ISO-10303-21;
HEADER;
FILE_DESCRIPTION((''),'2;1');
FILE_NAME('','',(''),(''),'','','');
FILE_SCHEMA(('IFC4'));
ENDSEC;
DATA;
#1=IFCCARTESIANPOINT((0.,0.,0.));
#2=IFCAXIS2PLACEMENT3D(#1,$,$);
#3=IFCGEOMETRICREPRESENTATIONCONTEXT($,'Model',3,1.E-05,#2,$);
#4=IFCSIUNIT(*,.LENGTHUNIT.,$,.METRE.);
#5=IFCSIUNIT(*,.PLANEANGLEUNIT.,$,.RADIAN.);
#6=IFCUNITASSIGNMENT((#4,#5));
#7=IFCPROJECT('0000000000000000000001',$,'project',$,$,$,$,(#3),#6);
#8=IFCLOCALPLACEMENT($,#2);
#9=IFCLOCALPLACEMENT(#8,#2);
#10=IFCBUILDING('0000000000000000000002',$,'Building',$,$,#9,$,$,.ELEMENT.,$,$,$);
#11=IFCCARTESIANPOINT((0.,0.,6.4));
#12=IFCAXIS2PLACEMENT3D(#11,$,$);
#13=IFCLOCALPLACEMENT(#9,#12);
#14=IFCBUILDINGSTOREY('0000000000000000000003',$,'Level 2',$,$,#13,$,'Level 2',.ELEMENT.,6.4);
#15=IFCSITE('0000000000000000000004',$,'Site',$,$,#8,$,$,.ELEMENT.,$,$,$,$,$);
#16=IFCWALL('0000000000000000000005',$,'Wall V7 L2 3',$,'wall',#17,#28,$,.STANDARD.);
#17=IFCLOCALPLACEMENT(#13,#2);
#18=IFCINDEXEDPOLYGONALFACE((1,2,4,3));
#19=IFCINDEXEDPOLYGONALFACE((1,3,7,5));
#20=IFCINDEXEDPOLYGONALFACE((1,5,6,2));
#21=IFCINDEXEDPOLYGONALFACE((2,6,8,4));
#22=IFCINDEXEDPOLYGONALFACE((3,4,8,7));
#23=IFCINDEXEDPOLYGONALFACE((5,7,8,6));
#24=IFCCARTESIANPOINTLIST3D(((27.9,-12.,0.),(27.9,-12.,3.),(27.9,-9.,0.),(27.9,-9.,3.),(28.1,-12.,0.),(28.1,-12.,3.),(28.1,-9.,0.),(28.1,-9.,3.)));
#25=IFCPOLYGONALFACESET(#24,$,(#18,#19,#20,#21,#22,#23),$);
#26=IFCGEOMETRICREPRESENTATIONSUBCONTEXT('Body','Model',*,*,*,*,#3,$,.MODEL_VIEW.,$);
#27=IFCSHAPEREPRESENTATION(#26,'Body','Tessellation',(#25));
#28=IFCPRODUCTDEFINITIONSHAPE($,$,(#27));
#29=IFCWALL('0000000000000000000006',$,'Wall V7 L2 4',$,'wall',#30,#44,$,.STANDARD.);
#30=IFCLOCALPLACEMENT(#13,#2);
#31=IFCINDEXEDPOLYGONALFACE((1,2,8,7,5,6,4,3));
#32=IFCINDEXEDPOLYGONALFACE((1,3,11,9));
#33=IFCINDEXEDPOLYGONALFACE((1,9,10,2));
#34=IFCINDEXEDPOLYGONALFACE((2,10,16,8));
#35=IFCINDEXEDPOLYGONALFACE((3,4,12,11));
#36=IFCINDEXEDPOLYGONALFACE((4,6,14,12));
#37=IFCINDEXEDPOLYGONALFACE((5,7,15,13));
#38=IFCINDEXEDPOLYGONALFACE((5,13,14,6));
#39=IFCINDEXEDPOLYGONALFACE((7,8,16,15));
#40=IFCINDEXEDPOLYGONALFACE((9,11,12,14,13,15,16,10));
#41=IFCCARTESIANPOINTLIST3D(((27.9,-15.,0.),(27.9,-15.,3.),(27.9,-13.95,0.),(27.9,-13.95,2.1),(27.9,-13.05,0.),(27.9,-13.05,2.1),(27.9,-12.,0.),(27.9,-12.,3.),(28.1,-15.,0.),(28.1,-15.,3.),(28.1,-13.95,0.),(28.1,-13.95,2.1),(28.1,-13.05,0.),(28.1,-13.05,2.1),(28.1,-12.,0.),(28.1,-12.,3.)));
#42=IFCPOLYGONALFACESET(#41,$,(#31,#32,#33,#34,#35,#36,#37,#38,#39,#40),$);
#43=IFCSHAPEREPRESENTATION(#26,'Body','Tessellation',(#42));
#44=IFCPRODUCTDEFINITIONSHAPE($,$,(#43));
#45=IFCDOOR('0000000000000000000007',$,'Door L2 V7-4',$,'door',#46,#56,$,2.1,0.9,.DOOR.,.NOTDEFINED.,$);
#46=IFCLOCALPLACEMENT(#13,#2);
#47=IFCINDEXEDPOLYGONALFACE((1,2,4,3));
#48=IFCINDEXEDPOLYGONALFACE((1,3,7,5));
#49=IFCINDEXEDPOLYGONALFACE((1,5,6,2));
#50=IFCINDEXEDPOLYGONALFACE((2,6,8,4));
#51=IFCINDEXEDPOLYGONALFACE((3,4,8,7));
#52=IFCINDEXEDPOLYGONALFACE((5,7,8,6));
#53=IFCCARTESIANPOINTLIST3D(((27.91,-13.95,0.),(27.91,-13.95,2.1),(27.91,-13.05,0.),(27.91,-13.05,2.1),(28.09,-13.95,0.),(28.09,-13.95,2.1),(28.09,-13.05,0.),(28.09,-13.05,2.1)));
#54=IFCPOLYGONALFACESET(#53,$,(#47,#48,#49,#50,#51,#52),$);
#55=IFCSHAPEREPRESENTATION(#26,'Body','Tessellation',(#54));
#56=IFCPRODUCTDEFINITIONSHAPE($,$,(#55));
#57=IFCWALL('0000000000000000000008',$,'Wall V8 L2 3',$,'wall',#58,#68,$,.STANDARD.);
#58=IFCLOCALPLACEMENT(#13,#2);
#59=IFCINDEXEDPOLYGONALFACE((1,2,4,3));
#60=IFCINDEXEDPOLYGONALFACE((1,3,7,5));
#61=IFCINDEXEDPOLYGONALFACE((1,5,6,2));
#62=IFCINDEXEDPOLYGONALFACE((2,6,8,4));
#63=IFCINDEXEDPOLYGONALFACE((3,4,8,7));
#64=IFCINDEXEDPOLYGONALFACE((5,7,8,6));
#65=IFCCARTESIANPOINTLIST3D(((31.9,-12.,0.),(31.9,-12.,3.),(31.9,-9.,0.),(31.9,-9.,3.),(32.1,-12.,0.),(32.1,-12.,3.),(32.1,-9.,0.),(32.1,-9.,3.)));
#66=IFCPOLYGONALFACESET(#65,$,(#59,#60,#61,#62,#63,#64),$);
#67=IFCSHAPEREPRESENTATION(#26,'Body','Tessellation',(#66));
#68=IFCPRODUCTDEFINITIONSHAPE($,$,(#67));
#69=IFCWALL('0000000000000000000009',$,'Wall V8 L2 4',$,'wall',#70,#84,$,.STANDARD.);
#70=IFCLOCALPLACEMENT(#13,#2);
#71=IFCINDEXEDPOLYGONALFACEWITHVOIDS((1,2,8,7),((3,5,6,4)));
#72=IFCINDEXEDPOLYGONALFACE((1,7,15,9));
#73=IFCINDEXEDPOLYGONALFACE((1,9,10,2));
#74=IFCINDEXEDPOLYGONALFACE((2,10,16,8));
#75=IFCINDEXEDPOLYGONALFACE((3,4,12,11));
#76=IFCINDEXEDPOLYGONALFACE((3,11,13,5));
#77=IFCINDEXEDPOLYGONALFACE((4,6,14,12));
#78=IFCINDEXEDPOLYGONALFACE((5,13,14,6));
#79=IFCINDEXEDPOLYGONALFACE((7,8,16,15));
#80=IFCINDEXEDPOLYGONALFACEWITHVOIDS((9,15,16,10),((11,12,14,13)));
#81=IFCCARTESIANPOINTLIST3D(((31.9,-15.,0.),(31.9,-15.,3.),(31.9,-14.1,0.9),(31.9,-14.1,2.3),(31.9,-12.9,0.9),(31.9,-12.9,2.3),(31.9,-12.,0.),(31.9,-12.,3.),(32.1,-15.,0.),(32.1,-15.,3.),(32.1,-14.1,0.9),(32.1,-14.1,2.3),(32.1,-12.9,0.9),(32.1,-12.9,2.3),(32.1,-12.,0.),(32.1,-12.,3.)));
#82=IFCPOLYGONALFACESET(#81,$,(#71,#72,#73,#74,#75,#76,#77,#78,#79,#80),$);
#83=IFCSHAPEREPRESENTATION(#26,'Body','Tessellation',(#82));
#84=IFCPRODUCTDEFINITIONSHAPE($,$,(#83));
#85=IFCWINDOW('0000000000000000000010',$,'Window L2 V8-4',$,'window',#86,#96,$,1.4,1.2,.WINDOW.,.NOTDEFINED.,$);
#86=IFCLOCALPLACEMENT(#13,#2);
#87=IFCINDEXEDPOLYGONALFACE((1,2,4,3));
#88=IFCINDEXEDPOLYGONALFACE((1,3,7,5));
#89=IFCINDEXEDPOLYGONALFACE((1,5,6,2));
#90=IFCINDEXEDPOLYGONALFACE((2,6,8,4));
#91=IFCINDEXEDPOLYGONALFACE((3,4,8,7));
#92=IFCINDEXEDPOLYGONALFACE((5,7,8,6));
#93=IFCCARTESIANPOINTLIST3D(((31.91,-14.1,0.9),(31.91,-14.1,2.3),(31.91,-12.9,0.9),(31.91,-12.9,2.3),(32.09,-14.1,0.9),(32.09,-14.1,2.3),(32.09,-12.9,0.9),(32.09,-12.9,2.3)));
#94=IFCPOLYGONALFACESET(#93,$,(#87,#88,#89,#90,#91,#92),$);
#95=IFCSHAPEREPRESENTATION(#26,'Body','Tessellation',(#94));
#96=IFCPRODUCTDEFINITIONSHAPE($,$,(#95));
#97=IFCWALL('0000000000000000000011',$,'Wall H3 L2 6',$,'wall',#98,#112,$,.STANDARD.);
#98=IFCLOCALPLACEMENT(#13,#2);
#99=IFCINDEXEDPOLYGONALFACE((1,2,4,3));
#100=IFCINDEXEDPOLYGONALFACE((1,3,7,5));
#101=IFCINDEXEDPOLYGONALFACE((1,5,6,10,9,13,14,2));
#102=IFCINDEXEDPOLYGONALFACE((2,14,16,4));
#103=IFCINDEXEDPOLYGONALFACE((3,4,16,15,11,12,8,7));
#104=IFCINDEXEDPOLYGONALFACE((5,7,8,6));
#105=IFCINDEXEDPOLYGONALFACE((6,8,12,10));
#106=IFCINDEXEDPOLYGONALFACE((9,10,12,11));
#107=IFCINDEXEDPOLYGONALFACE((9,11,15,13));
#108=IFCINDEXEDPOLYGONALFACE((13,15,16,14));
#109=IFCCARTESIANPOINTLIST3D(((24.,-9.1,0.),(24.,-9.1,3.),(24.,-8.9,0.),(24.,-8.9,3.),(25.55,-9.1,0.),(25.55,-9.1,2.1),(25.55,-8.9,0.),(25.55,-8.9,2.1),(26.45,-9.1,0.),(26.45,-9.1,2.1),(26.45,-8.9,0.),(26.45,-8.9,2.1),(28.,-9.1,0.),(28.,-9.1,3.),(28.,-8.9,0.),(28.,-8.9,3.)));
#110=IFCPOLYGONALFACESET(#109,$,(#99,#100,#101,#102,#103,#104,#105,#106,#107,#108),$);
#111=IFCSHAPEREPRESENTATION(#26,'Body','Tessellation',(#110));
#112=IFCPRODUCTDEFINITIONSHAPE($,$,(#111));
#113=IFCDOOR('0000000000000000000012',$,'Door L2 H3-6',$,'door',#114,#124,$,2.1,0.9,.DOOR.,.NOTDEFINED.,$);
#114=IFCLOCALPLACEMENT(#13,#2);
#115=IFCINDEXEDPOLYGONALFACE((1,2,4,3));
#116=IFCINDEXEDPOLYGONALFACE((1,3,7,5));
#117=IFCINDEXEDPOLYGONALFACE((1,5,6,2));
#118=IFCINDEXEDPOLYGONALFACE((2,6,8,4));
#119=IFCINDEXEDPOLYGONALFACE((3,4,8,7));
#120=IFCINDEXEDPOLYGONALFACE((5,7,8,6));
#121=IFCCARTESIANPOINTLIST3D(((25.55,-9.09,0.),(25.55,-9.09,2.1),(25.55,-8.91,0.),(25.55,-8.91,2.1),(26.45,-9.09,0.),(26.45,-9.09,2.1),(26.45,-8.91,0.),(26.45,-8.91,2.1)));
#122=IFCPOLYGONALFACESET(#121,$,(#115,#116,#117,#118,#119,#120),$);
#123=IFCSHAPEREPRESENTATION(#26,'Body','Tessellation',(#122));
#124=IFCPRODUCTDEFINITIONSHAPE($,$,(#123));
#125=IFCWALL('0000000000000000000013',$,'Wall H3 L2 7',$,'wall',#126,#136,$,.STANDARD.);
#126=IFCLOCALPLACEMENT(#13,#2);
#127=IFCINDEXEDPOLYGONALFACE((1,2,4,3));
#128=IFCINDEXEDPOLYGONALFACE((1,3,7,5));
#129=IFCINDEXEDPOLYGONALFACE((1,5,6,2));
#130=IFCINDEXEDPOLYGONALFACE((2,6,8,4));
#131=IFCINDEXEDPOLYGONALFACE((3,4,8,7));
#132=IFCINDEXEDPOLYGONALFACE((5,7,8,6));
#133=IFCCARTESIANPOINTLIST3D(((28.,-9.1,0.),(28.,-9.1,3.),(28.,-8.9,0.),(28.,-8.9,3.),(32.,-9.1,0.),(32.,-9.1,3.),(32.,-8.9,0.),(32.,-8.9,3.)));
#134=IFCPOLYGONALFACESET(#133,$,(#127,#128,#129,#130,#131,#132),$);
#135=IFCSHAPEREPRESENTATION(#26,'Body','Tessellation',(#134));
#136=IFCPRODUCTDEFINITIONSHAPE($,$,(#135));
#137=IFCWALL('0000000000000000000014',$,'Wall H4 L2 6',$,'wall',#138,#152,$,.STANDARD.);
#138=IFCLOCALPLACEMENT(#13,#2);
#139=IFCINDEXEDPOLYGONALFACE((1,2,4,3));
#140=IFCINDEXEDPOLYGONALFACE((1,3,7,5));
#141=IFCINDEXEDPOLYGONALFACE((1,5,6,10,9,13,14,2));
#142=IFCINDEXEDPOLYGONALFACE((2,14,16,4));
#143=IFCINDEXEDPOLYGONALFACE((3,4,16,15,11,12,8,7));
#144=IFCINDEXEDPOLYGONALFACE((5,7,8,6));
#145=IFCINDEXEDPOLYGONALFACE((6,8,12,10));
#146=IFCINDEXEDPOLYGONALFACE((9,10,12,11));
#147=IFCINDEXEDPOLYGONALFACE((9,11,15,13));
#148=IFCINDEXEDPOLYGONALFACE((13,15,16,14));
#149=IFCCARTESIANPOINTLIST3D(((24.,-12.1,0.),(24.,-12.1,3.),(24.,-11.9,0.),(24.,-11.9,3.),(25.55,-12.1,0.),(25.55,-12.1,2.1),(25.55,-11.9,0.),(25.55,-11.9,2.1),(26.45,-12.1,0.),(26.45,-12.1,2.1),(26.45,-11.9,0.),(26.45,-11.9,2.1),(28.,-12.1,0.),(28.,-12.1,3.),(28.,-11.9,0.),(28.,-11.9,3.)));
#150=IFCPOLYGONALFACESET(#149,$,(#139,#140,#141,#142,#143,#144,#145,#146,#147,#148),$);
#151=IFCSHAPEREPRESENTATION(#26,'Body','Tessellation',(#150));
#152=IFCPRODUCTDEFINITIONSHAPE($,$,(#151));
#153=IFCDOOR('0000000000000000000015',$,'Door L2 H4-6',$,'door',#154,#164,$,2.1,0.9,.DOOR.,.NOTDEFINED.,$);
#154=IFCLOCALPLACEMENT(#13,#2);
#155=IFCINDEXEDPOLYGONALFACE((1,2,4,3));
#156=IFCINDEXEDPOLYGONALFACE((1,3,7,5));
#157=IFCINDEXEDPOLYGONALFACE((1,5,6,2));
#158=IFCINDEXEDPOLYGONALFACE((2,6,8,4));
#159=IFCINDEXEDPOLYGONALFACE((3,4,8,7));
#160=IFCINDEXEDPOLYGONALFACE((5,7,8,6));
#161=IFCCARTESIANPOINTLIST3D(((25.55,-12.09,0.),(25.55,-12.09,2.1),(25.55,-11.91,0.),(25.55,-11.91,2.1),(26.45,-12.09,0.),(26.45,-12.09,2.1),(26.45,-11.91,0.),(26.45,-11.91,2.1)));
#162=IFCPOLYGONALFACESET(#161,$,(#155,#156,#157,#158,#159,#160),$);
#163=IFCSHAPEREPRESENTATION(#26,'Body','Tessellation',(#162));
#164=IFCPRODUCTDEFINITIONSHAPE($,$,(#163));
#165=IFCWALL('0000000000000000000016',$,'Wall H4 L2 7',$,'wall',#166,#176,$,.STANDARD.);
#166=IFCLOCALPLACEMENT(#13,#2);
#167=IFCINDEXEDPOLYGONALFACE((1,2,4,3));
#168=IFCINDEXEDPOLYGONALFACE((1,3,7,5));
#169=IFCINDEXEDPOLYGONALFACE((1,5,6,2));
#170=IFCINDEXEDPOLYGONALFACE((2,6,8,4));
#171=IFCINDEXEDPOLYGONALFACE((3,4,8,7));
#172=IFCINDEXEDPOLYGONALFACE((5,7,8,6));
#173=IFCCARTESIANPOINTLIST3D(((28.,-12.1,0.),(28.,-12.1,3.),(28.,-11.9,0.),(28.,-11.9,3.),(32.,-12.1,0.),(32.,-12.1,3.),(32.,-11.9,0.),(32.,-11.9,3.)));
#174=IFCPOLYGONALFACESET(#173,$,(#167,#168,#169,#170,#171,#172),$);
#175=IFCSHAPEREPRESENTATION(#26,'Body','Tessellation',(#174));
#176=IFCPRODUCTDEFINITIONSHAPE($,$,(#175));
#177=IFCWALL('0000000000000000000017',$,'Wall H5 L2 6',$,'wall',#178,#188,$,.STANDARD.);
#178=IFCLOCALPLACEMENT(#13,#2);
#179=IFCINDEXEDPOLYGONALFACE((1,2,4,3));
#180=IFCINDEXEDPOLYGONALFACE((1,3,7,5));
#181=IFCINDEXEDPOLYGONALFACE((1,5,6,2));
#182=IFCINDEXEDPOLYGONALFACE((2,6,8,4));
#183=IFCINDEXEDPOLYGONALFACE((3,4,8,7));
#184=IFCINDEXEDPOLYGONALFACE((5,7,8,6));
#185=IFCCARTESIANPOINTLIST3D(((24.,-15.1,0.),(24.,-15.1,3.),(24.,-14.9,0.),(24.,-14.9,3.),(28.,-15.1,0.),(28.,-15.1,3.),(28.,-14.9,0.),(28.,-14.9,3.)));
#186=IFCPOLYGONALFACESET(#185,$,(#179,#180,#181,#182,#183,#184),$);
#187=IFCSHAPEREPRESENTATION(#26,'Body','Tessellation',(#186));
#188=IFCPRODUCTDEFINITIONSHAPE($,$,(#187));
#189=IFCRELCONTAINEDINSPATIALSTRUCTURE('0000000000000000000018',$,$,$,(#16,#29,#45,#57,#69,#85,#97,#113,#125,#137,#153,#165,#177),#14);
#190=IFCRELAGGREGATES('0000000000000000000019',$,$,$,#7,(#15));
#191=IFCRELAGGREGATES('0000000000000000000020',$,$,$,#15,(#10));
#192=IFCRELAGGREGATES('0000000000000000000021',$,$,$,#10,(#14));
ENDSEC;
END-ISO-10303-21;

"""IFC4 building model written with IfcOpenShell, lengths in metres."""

from ifc_helpers import new_model, si_unit, frame, frame_2d, origin, origin_2d, place, context, subcontext, project, spatial, rectangle, extrude, element, fill, save


model = new_model("IFC4")

# Units and contexts
model_context = context("Model", 3, precision=1e-05, world=origin())
body_context = subcontext(model_context, "Body", "Model", "MODEL_VIEW")
ifc_project = project(units=[si_unit("LENGTHUNIT", "METRE"), si_unit("PLANEANGLEUNIT", "RADIAN")], contexts=[model_context])

# Site, building, storey
site_placement = place(None, origin())
site = spatial("IfcSite", under=ifc_project, at=site_placement, Name="Site", CompositionType="ELEMENT")
building_placement = place(site_placement, origin())
building = spatial("IfcBuilding", under=site, at=building_placement, Name="Building", CompositionType="ELEMENT")
storey_placement = place(building_placement, frame((0.0, 0.0, 6.4)))
storey = spatial("IfcBuildingStorey", under=building, at=storey_placement, Name="Level 2", LongName="Level 2", CompositionType="ELEMENT", Elevation=6.4)

# Wall
wall_1_placement = place(storey_placement, frame((28.0, -9.0, 0.0), z_axis=(0.0, 0.0, 1.0), x_axis=(0.0, -1.0, 0.0)))
element("IfcWall", 1, at=wall_1_placement, inside=storey, Name="Wall V7 L2 3", ObjectType="wall", PredefinedType="STANDARD", context=body_context, shape_type="SweptSolid", body=[
    extrude(rectangle(XDim=3.0, YDim=0.2, at=frame_2d((1.5, 0.0))), origin(), (0.0, 0.0, 1.0), 3.0),
])

# Wall, opening, door
wall_2_placement = place(storey_placement, frame((28.0, -12.0, 0.0), z_axis=(0.0, 0.0, 1.0), x_axis=(0.0, -1.0, 0.0)))
wall_2 = element("IfcWall", 2, at=wall_2_placement, inside=storey, Name="Wall V7 L2 4", ObjectType="wall", PredefinedType="STANDARD", context=body_context, shape_type="SweptSolid", body=[
    extrude(rectangle(XDim=3.0, YDim=0.2, at=frame_2d((1.5, 0.0))), origin(), (0.0, 0.0, 1.0), 3.0),
])
opening_1_placement = place(storey_placement, frame((28.0, -13.5, 0.0), z_axis=(0.0, 0.0, 1.0), x_axis=(0.0, -1.0, 0.0)))
opening_1 = element("IfcOpeningElement", 3, at=opening_1_placement, cuts=wall_2, ObjectType="Opening", PredefinedType="OPENING", context=body_context, shape_type="SweptSolid", body=[
    extrude(rectangle(XDim=0.9, YDim=0.22, at=origin_2d()), origin(), (0.0, 0.0, 1.0), 2.1),
])
door_1_placement = place(storey_placement, frame((28.0, -13.5, 0.0), z_axis=(0.0, 0.0, 1.0), x_axis=(0.0, -1.0, 0.0)))
door_1 = element("IfcDoor", 4, at=door_1_placement, inside=storey, Name="Door L2 V7-4", ObjectType="door", OperationType="NOTDEFINED", OverallHeight=2.1, OverallWidth=0.9, PredefinedType="DOOR", context=body_context, shape_type="SweptSolid", body=[
    extrude(rectangle(XDim=0.9, YDim=0.18, at=origin_2d()), origin(), (0.0, 0.0, 1.0), 2.1),
])
fill(opening_1, door_1)

# Wall
wall_3_placement = place(storey_placement, frame((32.0, -9.0, 0.0), z_axis=(0.0, 0.0, 1.0), x_axis=(0.0, -1.0, 0.0)))
element("IfcWall", 5, at=wall_3_placement, inside=storey, Name="Wall V8 L2 3", ObjectType="wall", PredefinedType="STANDARD", context=body_context, shape_type="SweptSolid", body=[
    extrude(rectangle(XDim=3.0, YDim=0.2, at=frame_2d((1.5, 0.0))), origin(), (0.0, 0.0, 1.0), 3.0),
])

# Wall, opening, window
wall_4_placement = place(storey_placement, frame((32.0, -12.0, 0.0), z_axis=(0.0, 0.0, 1.0), x_axis=(0.0, -1.0, 0.0)))
wall_4 = element("IfcWall", 6, at=wall_4_placement, inside=storey, Name="Wall V8 L2 4", ObjectType="wall", PredefinedType="STANDARD", context=body_context, shape_type="SweptSolid", body=[
    extrude(rectangle(XDim=3.0, YDim=0.2, at=frame_2d((1.5, 0.0))), origin(), (0.0, 0.0, 1.0), 3.0),
])
opening_2_placement = place(storey_placement, frame((32.0, -13.5, 0.9), z_axis=(0.0, 0.0, 1.0), x_axis=(0.0, -1.0, 0.0)))
opening_2 = element("IfcOpeningElement", 7, at=opening_2_placement, cuts=wall_4, ObjectType="Opening", PredefinedType="OPENING", context=body_context, shape_type="SweptSolid", body=[
    extrude(rectangle(XDim=1.2, YDim=0.22, at=origin_2d()), origin(), (0.0, 0.0, 1.0), 1.4),
])
window_1_placement = place(storey_placement, frame((32.0, -13.5, 0.9), z_axis=(0.0, 0.0, 1.0), x_axis=(0.0, -1.0, 0.0)))
window_1 = element("IfcWindow", 8, at=window_1_placement, inside=storey, Name="Window L2 V8-4", ObjectType="window", OverallHeight=1.4, OverallWidth=1.2, PartitioningType="NOTDEFINED", PredefinedType="WINDOW", context=body_context, shape_type="SweptSolid", body=[
    extrude(rectangle(XDim=1.2, YDim=0.18, at=origin_2d()), origin(), (0.0, 0.0, 1.0), 1.4),
])
fill(opening_2, window_1)

# Wall, opening, door
wall_5_placement = place(storey_placement, frame((24.0, -9.0, 0.0), z_axis=(0.0, 0.0, 1.0), x_axis=(1.0, 0.0, 0.0)))
wall_5 = element("IfcWall", 9, at=wall_5_placement, inside=storey, Name="Wall H3 L2 6", ObjectType="wall", PredefinedType="STANDARD", context=body_context, shape_type="SweptSolid", body=[
    extrude(rectangle(XDim=4.0, YDim=0.2, at=frame_2d((2.0, 0.0))), origin(), (0.0, 0.0, 1.0), 3.0),
])
opening_3_placement = place(storey_placement, frame((26.0, -9.0, 0.0), z_axis=(0.0, 0.0, 1.0), x_axis=(1.0, 0.0, 0.0)))
opening_3 = element("IfcOpeningElement", 10, at=opening_3_placement, cuts=wall_5, ObjectType="Opening", PredefinedType="OPENING", context=body_context, shape_type="SweptSolid", body=[
    extrude(rectangle(XDim=0.9, YDim=0.22, at=origin_2d()), origin(), (0.0, 0.0, 1.0), 2.1),
])
door_2_placement = place(storey_placement, frame((26.0, -9.0, 0.0), z_axis=(0.0, 0.0, 1.0), x_axis=(1.0, 0.0, 0.0)))
door_2 = element("IfcDoor", 11, at=door_2_placement, inside=storey, Name="Door L2 H3-6", ObjectType="door", OperationType="NOTDEFINED", OverallHeight=2.1, OverallWidth=0.9, PredefinedType="DOOR", context=body_context, shape_type="SweptSolid", body=[
    extrude(rectangle(XDim=0.9, YDim=0.18, at=origin_2d()), origin(), (0.0, 0.0, 1.0), 2.1),
])
fill(opening_3, door_2)

# Wall
wall_6_placement = place(storey_placement, frame((28.0, -9.0, 0.0), z_axis=(0.0, 0.0, 1.0), x_axis=(1.0, 0.0, 0.0)))
element("IfcWall", 12, at=wall_6_placement, inside=storey, Name="Wall H3 L2 7", ObjectType="wall", PredefinedType="STANDARD", context=body_context, shape_type="SweptSolid", body=[
    extrude(rectangle(XDim=4.0, YDim=0.2, at=frame_2d((2.0, 0.0))), origin(), (0.0, 0.0, 1.0), 3.0),
])

# Wall, opening, door
wall_7_placement = place(storey_placement, frame((24.0, -12.0, 0.0), z_axis=(0.0, 0.0, 1.0), x_axis=(1.0, 0.0, 0.0)))
wall_7 = element("IfcWall", 13, at=wall_7_placement, inside=storey, Name="Wall H4 L2 6", ObjectType="wall", PredefinedType="STANDARD", context=body_context, shape_type="SweptSolid", body=[
    extrude(rectangle(XDim=4.0, YDim=0.2, at=frame_2d((2.0, 0.0))), origin(), (0.0, 0.0, 1.0), 3.0),
])
opening_4_placement = place(storey_placement, frame((26.0, -12.0, 0.0), z_axis=(0.0, 0.0, 1.0), x_axis=(1.0, 0.0, 0.0)))
opening_4 = element("IfcOpeningElement", 14, at=opening_4_placement, cuts=wall_7, ObjectType="Opening", PredefinedType="OPENING", context=body_context, shape_type="SweptSolid", body=[
    extrude(rectangle(XDim=0.9, YDim=0.22, at=origin_2d()), origin(), (0.0, 0.0, 1.0), 2.1),
])
door_3_placement = place(storey_placement, frame((26.0, -12.0, 0.0), z_axis=(0.0, 0.0, 1.0), x_axis=(1.0, 0.0, 0.0)))
door_3 = element("IfcDoor", 15, at=door_3_placement, inside=storey, Name="Door L2 H4-6", ObjectType="door", OperationType="NOTDEFINED", OverallHeight=2.1, OverallWidth=0.9, PredefinedType="DOOR", context=body_context, shape_type="SweptSolid", body=[
    extrude(rectangle(XDim=0.9, YDim=0.18, at=origin_2d()), origin(), (0.0, 0.0, 1.0), 2.1),
])
fill(opening_4, door_3)

# Walls
for number, where, z_axis, x_axis, name in (
    (16, (28.0, -12.0, 0.0), (0.0, 0.0, 1.0), (1.0, 0.0, 0.0), "Wall H4 L2 7"),
    (17, (24.0, -15.0, 0.0), (0.0, 0.0, 1.0), (1.0, 0.0, 0.0), "Wall H5 L2 6"),
):
    element("IfcWall", number, at=place(storey_placement, frame(where, z_axis=z_axis, x_axis=x_axis)), inside=storey, Name=name, ObjectType="wall", PredefinedType="STANDARD", context=body_context, shape_type="SweptSolid", body=[
        extrude(rectangle(XDim=4.0, YDim=0.2, at=frame_2d((2.0, 0.0))), origin(), (0.0, 0.0, 1.0), 3.0),
    ])

save(model, "model.ifc")
